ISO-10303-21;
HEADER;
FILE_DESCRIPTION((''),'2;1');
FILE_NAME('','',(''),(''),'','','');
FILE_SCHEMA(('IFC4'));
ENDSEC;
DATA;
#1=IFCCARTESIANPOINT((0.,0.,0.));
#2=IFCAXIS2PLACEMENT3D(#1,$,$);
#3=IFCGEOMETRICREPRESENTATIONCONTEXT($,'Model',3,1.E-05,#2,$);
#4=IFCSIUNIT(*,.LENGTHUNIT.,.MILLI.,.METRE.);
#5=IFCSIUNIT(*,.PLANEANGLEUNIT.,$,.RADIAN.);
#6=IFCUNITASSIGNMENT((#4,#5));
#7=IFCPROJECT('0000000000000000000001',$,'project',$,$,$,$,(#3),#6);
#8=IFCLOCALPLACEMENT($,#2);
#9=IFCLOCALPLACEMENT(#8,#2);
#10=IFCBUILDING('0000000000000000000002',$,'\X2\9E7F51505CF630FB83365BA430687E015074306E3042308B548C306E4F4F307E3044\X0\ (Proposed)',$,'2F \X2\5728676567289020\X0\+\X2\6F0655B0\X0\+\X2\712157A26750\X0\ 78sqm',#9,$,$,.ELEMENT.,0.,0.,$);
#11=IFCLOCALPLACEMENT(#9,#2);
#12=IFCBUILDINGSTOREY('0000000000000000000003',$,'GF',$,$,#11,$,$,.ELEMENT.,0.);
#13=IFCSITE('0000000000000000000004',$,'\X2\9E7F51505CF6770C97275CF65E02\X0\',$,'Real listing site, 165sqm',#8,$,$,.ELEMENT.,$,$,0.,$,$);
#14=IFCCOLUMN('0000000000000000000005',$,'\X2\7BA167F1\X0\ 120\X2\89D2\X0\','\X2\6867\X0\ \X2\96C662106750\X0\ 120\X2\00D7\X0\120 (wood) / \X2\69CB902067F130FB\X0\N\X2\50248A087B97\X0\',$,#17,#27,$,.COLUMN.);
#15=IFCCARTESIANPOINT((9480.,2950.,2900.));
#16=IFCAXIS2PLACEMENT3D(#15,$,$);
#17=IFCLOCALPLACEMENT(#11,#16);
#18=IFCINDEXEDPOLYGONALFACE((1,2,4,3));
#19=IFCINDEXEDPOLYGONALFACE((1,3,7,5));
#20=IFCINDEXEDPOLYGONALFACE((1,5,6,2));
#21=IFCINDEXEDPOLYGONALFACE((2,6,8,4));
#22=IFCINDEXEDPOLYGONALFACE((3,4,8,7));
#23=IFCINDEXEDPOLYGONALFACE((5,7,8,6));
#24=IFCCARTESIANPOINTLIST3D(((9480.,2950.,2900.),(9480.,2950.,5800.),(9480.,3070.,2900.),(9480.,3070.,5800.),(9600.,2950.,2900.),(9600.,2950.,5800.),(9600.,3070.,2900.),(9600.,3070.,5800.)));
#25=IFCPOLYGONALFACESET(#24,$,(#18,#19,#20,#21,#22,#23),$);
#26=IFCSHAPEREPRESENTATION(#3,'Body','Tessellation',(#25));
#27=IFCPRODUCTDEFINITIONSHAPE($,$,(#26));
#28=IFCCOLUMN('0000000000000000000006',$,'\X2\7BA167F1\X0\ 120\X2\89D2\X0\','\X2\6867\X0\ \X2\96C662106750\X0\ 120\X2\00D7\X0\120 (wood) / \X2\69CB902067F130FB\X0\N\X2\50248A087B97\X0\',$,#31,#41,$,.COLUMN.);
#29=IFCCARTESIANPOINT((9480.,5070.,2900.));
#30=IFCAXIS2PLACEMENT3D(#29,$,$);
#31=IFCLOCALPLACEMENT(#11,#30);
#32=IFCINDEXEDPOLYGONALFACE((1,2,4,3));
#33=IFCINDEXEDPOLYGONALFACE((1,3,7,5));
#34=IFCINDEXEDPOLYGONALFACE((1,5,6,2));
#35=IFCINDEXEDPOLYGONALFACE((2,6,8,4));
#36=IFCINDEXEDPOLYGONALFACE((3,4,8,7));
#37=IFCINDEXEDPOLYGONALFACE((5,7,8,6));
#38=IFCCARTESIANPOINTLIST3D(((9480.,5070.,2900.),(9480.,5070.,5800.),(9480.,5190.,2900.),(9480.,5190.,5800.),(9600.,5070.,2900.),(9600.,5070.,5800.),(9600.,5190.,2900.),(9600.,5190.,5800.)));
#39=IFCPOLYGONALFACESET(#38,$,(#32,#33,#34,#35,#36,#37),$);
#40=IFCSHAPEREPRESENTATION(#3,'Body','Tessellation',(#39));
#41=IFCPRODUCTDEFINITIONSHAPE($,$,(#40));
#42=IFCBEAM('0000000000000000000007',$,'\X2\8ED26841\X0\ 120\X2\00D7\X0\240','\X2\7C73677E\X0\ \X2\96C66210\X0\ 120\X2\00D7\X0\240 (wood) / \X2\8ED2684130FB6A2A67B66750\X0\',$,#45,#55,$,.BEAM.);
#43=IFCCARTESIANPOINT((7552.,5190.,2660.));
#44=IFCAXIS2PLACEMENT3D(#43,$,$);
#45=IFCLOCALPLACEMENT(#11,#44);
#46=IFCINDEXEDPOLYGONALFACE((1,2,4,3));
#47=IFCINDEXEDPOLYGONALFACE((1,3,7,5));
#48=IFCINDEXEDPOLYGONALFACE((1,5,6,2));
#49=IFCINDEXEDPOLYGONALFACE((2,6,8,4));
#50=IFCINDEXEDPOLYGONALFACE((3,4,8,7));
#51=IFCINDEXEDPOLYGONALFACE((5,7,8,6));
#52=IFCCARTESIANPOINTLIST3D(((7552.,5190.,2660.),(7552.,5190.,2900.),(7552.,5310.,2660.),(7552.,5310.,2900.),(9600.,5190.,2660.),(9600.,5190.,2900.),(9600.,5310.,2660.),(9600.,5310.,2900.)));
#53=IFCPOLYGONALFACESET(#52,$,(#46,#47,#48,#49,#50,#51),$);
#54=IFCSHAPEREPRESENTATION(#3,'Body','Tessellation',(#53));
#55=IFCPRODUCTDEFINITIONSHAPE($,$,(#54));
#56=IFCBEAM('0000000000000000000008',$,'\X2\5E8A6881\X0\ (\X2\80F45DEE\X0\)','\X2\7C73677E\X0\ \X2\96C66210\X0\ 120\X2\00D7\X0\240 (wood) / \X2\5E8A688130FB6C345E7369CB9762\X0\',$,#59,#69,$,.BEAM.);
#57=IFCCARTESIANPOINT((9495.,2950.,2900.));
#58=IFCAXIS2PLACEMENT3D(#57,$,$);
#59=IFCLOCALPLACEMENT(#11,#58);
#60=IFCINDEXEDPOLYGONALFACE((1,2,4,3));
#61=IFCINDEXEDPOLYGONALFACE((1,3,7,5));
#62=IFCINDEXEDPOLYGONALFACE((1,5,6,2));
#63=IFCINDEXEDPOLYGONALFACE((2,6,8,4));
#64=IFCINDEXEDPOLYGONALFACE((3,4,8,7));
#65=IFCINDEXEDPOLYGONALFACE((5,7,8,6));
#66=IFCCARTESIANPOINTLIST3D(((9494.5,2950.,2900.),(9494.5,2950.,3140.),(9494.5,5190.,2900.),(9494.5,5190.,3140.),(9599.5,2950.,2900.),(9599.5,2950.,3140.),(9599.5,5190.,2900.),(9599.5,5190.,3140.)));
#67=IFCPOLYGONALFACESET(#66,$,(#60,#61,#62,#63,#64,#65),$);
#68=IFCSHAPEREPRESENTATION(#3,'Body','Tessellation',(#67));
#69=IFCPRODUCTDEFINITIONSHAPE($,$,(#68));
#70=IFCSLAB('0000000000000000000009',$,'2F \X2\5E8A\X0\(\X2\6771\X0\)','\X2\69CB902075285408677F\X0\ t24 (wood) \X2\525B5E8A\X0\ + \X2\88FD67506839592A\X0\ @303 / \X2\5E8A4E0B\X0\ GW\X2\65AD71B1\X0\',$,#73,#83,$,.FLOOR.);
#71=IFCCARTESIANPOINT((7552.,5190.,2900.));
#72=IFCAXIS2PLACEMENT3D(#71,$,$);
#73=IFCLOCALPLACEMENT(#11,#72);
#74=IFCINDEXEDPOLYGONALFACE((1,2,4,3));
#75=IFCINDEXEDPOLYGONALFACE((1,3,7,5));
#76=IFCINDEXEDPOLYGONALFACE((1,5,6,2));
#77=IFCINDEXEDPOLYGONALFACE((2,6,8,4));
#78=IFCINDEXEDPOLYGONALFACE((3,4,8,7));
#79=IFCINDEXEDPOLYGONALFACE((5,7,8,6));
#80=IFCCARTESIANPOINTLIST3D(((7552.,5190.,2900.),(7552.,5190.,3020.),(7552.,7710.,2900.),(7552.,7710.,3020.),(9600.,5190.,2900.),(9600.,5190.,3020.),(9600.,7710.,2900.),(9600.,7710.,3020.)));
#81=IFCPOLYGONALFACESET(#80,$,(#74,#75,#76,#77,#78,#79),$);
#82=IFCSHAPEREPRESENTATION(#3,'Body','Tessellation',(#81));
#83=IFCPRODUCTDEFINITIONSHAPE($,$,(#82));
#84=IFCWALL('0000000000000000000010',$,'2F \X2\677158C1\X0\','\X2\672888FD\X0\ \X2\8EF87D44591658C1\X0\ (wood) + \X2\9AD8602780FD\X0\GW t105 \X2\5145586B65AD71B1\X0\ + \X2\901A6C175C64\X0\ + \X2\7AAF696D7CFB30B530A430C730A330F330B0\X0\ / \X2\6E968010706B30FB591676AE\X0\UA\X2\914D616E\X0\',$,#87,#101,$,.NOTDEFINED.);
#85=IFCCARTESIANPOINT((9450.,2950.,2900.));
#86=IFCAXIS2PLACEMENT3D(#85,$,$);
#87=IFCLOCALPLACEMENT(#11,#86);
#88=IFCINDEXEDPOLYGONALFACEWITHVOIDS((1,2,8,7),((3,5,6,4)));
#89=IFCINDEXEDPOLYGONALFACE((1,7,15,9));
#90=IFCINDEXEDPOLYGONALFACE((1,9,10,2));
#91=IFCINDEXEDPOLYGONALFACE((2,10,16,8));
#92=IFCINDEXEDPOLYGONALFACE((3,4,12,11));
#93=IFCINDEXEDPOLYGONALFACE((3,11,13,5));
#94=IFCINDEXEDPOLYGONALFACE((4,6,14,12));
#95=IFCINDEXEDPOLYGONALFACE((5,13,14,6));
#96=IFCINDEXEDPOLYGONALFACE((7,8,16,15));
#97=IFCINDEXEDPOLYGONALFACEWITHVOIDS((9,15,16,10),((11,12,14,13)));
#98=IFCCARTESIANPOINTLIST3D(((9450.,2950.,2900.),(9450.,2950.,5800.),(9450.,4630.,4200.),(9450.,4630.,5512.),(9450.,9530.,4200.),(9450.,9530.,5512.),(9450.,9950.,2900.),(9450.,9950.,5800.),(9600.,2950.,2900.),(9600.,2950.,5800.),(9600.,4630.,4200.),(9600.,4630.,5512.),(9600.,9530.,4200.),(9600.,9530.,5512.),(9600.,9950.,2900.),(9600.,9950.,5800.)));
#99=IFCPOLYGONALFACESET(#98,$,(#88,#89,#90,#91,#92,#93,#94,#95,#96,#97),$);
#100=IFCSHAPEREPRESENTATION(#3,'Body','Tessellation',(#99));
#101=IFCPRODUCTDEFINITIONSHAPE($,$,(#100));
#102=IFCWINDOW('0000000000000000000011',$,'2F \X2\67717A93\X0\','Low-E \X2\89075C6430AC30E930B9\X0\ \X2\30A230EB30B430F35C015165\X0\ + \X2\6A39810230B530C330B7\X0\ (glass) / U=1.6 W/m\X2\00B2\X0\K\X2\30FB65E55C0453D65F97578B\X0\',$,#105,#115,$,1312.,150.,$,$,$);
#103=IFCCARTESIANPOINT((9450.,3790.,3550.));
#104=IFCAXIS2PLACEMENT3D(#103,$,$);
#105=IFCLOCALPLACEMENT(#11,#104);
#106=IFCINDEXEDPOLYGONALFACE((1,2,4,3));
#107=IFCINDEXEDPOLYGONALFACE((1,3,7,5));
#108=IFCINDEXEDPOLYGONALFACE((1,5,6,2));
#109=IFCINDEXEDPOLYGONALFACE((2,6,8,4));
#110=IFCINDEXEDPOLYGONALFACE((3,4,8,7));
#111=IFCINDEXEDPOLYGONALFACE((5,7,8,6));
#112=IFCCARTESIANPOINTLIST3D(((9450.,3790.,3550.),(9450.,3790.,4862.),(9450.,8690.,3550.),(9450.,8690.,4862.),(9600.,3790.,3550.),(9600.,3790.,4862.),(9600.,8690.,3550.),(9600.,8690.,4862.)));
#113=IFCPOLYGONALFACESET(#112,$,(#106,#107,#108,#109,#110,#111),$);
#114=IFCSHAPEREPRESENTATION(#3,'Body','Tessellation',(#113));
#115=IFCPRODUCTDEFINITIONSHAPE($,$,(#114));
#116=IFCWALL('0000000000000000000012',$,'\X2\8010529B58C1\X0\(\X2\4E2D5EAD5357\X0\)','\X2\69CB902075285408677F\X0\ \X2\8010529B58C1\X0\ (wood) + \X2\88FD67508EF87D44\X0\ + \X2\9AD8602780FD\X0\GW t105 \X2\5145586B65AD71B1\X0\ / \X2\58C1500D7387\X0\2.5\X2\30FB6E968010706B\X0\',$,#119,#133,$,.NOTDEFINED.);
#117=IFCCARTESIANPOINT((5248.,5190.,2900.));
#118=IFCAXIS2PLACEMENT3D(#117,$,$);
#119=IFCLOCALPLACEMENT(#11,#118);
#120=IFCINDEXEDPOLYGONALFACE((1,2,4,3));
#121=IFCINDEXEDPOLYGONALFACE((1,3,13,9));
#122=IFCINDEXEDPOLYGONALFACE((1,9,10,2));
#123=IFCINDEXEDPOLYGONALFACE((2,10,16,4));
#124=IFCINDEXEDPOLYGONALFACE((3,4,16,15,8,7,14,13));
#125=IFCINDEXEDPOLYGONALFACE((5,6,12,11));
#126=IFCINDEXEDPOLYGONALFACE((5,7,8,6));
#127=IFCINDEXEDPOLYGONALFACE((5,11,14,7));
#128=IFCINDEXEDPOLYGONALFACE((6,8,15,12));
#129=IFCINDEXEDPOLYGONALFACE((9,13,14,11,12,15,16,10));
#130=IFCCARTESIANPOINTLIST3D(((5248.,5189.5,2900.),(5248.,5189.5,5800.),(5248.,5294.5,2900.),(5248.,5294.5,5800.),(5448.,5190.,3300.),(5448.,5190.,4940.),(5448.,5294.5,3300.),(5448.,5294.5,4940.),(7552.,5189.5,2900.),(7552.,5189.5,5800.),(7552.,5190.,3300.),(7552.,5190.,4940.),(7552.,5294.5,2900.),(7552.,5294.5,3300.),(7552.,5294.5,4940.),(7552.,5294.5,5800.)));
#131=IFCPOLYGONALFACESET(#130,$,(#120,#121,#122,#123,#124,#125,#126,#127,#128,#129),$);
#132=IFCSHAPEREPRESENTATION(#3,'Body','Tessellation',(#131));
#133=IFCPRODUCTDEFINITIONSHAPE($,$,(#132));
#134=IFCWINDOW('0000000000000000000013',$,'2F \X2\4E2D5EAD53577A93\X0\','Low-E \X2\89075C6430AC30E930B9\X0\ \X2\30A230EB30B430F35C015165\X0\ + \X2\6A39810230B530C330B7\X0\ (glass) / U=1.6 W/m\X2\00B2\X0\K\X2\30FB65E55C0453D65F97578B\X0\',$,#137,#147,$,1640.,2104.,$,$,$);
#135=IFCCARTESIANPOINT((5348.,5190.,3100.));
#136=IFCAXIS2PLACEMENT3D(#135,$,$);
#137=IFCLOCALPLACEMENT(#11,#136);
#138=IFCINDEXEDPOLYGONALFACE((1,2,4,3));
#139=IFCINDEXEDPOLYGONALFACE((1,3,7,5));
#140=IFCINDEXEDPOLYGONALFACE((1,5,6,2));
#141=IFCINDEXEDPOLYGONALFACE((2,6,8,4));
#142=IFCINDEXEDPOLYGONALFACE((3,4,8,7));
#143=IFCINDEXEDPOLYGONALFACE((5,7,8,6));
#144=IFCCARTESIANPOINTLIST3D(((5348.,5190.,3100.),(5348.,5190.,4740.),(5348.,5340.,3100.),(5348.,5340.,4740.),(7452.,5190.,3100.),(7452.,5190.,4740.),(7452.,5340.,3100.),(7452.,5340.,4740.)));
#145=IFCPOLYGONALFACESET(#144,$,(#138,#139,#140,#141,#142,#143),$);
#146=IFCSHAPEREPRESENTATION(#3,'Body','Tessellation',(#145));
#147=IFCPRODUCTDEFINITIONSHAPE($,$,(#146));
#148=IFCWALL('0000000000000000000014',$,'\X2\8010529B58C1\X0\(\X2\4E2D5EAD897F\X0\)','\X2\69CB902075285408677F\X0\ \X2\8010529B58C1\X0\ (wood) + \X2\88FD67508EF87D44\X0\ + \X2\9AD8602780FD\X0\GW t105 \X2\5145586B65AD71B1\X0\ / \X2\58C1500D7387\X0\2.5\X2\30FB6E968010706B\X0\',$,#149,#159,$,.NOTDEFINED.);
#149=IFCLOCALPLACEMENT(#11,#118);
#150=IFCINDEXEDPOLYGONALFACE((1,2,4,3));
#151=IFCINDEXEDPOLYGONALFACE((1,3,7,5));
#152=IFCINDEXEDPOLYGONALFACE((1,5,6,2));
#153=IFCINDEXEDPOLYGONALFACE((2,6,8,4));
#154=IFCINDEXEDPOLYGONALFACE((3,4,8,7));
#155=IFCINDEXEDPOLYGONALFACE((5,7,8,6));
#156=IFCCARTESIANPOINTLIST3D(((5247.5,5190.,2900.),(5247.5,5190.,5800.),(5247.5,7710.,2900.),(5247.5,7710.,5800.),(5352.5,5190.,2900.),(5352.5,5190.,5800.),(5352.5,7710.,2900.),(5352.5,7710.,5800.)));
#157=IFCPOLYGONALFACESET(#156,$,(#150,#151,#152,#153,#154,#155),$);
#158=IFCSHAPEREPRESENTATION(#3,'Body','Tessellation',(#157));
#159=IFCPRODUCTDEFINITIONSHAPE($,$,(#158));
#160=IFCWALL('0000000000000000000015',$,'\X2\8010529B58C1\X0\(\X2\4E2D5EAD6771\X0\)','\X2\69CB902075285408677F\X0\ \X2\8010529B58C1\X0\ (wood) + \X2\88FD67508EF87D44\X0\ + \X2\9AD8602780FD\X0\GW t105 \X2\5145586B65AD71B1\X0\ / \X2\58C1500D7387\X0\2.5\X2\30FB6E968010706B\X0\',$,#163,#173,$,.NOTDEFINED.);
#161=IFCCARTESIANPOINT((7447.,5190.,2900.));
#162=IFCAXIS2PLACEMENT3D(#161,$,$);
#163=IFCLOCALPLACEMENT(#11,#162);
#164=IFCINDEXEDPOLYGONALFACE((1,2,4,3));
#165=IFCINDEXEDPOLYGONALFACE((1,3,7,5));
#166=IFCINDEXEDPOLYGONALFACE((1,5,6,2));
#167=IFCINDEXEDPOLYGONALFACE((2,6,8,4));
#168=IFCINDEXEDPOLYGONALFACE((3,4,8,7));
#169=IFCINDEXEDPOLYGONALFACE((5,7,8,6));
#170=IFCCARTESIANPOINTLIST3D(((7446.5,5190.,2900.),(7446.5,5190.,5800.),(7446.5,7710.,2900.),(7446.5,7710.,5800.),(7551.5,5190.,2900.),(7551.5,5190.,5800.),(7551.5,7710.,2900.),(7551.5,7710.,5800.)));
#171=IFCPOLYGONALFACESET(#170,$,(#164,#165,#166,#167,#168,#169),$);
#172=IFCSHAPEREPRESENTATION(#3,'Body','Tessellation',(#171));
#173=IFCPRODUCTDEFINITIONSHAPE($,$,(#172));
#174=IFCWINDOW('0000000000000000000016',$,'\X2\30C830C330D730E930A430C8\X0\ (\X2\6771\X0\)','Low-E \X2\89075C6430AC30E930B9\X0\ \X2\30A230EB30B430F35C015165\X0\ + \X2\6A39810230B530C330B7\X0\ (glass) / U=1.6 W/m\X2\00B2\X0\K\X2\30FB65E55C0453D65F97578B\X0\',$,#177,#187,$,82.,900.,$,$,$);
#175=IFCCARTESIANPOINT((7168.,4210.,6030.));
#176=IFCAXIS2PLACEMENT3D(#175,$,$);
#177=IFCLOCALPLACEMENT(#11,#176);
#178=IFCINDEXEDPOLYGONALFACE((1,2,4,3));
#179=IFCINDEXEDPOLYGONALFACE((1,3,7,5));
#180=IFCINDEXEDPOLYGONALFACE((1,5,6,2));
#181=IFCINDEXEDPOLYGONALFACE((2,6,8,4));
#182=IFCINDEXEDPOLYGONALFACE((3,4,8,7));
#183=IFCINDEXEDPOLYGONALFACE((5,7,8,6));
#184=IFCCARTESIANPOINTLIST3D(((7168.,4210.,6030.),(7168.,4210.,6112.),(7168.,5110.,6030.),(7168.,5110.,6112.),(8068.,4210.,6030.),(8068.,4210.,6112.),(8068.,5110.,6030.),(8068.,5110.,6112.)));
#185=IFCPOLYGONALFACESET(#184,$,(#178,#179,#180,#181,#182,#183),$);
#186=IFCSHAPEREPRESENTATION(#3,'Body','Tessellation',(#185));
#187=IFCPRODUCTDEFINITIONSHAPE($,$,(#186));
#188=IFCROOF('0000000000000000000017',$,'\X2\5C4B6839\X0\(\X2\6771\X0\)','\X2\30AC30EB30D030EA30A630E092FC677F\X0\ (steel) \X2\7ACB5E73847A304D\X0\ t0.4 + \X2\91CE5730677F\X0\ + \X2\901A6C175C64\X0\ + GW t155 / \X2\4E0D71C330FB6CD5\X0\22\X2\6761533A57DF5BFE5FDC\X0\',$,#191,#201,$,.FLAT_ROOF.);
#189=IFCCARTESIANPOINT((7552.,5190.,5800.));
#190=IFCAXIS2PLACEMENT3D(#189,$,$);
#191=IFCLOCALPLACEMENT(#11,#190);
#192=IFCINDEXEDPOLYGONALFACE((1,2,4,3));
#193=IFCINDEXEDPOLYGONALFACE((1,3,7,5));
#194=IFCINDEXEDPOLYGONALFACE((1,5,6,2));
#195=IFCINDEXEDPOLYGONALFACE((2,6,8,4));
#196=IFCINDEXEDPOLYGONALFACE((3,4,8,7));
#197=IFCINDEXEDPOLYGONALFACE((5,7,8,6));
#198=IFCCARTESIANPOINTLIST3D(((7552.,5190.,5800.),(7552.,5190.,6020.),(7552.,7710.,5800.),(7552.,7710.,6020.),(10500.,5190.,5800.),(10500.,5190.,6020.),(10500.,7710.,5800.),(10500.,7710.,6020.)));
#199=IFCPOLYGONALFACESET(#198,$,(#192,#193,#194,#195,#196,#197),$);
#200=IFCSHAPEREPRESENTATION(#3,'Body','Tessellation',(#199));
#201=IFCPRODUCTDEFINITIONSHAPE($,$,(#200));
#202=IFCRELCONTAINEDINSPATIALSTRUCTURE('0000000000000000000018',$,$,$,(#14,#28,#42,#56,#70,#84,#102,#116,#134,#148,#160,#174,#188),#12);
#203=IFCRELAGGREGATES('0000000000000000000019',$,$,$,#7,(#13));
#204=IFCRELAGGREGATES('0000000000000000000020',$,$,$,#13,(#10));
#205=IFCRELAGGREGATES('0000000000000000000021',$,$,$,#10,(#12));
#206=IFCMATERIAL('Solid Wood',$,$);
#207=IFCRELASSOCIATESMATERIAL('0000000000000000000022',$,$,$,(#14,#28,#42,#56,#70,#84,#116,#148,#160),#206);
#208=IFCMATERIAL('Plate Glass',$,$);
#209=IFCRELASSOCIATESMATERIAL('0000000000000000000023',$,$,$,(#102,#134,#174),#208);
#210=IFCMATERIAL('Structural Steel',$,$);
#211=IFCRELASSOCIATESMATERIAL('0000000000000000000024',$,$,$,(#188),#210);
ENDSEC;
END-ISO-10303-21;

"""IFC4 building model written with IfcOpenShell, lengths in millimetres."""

from ifc_helpers import new_model, si_unit, frame, frame_2d, origin, place, context, project, spatial, rectangle, extrude, material, element, fill, save


model = new_model("IFC4")

# Units and contexts
model_context = context("Model", 3, precision=1e-05, world=origin())
ifc_project = project(units=[si_unit("LENGTHUNIT", "METRE", prefix="MILLI"), si_unit("PLANEANGLEUNIT", "RADIAN")], contexts=[model_context])

# Site, building, storey
site_placement = place(None, origin())
site = spatial("IfcSite", under=ifc_project, at=site_placement, Name="鹿児島県霧島市", ObjectType="Real listing site, 165sqm", CompositionType="ELEMENT", RefElevation=0.0)
building_placement = place(site_placement, origin())
building = spatial("IfcBuilding", under=site, at=building_placement, Name="鹿児島・茶室と縁側のある和の住まい (Proposed)", ObjectType="2F 在来木造+漆喰+無垢材 78sqm", CompositionType="ELEMENT", ElevationOfRefHeight=0.0, ElevationOfTerrain=0.0)
storey_placement = place(building_placement, origin())
storey = spatial("IfcBuildingStorey", under=building, at=storey_placement, Name="GF", CompositionType="ELEMENT", Elevation=0.0)

# Columns
ifc_material_1 = material(Name="Solid Wood")
column_1_placement = place(storey_placement, frame((9480.0, 2950.0, 2900.0)))
element("IfcColumn", 1, at=column_1_placement, inside=storey, material=ifc_material_1, Name="管柱 120角", Description="桧 集成材 120×120 (wood) / 構造柱・N値計算", PredefinedType="COLUMN", context=model_context, shape_type="SweptSolid", body=[
    extrude(rectangle(XDim=120.0, YDim=120.0, at=frame_2d((60.0, 60.0))), frame((9480.0, 2950.0, 2900.0)), (0.0, 0.0, 1.0), 2900.0),
])
column_2_placement = place(storey_placement, frame((9480.0, 5070.0, 2900.0)))
element("IfcColumn", 2, at=column_2_placement, inside=storey, material=ifc_material_1, Name="管柱 120角", Description="桧 集成材 120×120 (wood) / 構造柱・N値計算", PredefinedType="COLUMN", context=model_context, shape_type="SweptSolid", body=[
    extrude(rectangle(XDim=120.0, YDim=120.0, at=frame_2d((60.0, 60.0))), frame((9480.0, 5070.0, 2900.0)), (0.0, 0.0, 1.0), 2900.0),
])

# Beams
beam_1_placement = place(storey_placement, frame((7552.0, 5190.0, 2660.0)))
element("IfcBeam", 3, at=beam_1_placement, inside=storey, material=ifc_material_1, Name="軒桁 120×240", Description="米松 集成 120×240 (wood) / 軒桁・横架材", PredefinedType="BEAM", context=model_context, shape_type="SweptSolid", body=[
    extrude(rectangle(XDim=2048.0, YDim=120.0, at=frame_2d((1024.0, 60.0))), frame((7552.0, 5190.0, 2660.0)), (0.0, 0.0, 1.0), 240.0),
])
beam_2_placement = place(storey_placement, frame((9495.0, 2950.0, 2900.0)))
element("IfcBeam", 4, at=beam_2_placement, inside=storey, material=ifc_material_1, Name="床梁 (胴差)", Description="米松 集成 120×240 (wood) / 床梁・水平構面", PredefinedType="BEAM", context=model_context, shape_type="SweptSolid", body=[
    extrude(rectangle(XDim=105.0, YDim=2240.0, at=frame_2d((52.0, 1120.0))), frame((9495.0, 2950.0, 2900.0)), (0.0, 0.0, 1.0), 240.0),
])

# Slab
slab_placement = place(storey_placement, frame((7552.0, 5190.0, 2900.0)))
element("IfcSlab", 5, at=slab_placement, inside=storey, material=ifc_material_1, Name="2F 床(東)", Description="構造用合板 t24 (wood) 剛床 + 製材根太 @303 / 床下 GW断熱", PredefinedType="FLOOR", context=model_context, shape_type="SweptSolid", body=[
    extrude(rectangle(XDim=2048.0, YDim=2520.0, at=frame_2d((1024.0, 1260.0))), frame((7552.0, 5190.0, 2900.0)), (0.0, 0.0, 1.0), 120.0),
])

# Walls, openings, windows
wall_1_placement = place(storey_placement, frame((9450.0, 2950.0, 2900.0)))
wall_1 = element("IfcWall", 6, at=wall_1_placement, inside=storey, material=ifc_material_1, Name="2F 東壁", Description="木製 軸組外壁 (wood) + 高性能GW t105 充填断熱 + 通気層 + 窯業系サイディング / 準耐火・外皮UA配慮", PredefinedType="NOTDEFINED", context=model_context, shape_type="SweptSolid", body=[
    extrude(rectangle(XDim=150.0, YDim=7000.0, at=frame_2d((75.0, 3500.0))), frame((9450.0, 2950.0, 2900.0)), (0.0, 0.0, 1.0), 2900.0),
])
opening_1_placement = place(storey_placement, frame((9450.0, 3790.0, 3550.0)))
opening_1 = element("IfcOpeningElement", 7, at=opening_1_placement, cuts=wall_1, PredefinedType="NOTDEFINED", context=model_context, shape_type="SweptSolid", body=[
    extrude(rectangle(XDim=150.0, YDim=4900.0, at=frame_2d((75.0, 2450.0))), frame((9450.0, 3790.0, 3550.0)), (0.0, 0.0, 1.0), 1312.0),
])
ifc_material_2 = material(Name="Plate Glass")
window_1_placement = place(storey_placement, frame((9450.0, 3790.0, 3550.0)))
window_1 = element("IfcWindow", 8, at=window_1_placement, inside=storey, material=ifc_material_2, Name="2F 東窓", Description="Low-E 複層ガラス アルゴン封入 + 樹脂サッシ (glass) / U=1.6 W/m²K・日射取得型", OverallHeight=1312.0, OverallWidth=150.0, context=model_context, shape_type="SweptSolid", body=[
    extrude(rectangle(XDim=150.0, YDim=4900.0, at=frame_2d((75.0, 2450.0))), frame((9450.0, 3790.0, 3550.0)), (0.0, 0.0, 1.0), 1312.0),
])
fill(opening_1, window_1)
wall_2_placement = place(storey_placement, frame((5248.0, 5190.0, 2900.0)))
wall_2 = element("IfcWall", 9, at=wall_2_placement, inside=storey, material=ifc_material_1, Name="耐力壁(中庭南)", Description="構造用合板 耐力壁 (wood) + 製材軸組 + 高性能GW t105 充填断熱 / 壁倍率2.5・準耐火", PredefinedType="NOTDEFINED", context=model_context, shape_type="SweptSolid", body=[
    extrude(rectangle(XDim=2304.0, YDim=105.0, at=frame_2d((1152.0, 52.0))), frame((5248.0, 5190.0, 2900.0)), (0.0, 0.0, 1.0), 2900.0),
])
opening_2_placement = place(storey_placement, frame((5348.0, 5190.0, 3100.0)))
opening_2 = element("IfcOpeningElement", 10, at=opening_2_placement, cuts=wall_2, PredefinedType="NOTDEFINED", context=model_context, shape_type="SweptSolid", body=[
    extrude(rectangle(XDim=2104.0, YDim=150.0, at=frame_2d((1052.0, 75.0))), frame((5348.0, 5190.0, 3100.0)), (0.0, 0.0, 1.0), 1640.0),
])
window_2_placement = place(storey_placement, frame((5348.0, 5190.0, 3100.0)))
window_2 = element("IfcWindow", 11, at=window_2_placement, inside=storey, material=ifc_material_2, Name="2F 中庭南窓", Description="Low-E 複層ガラス アルゴン封入 + 樹脂サッシ (glass) / U=1.6 W/m²K・日射取得型", OverallHeight=1640.0, OverallWidth=2104.0, context=model_context, shape_type="SweptSolid", body=[
    extrude(rectangle(XDim=2104.0, YDim=150.0, at=frame_2d((1052.0, 75.0))), frame((5348.0, 5190.0, 3100.0)), (0.0, 0.0, 1.0), 1640.0),
])
fill(opening_2, window_2)

# Walls
wall_3_placement = place(storey_placement, frame((5248.0, 5190.0, 2900.0)))
element("IfcWall", 12, at=wall_3_placement, inside=storey, material=ifc_material_1, Name="耐力壁(中庭西)", Description="構造用合板 耐力壁 (wood) + 製材軸組 + 高性能GW t105 充填断熱 / 壁倍率2.5・準耐火", PredefinedType="NOTDEFINED", context=model_context, shape_type="SweptSolid", body=[
    extrude(rectangle(XDim=105.0, YDim=2520.0, at=frame_2d((52.0, 1260.0))), frame((5248.0, 5190.0, 2900.0)), (0.0, 0.0, 1.0), 2900.0),
])
wall_4_placement = place(storey_placement, frame((7447.0, 5190.0, 2900.0)))
element("IfcWall", 13, at=wall_4_placement, inside=storey, material=ifc_material_1, Name="耐力壁(中庭東)", Description="構造用合板 耐力壁 (wood) + 製材軸組 + 高性能GW t105 充填断熱 / 壁倍率2.5・準耐火", PredefinedType="NOTDEFINED", context=model_context, shape_type="SweptSolid", body=[
    extrude(rectangle(XDim=105.0, YDim=2520.0, at=frame_2d((52.0, 1260.0))), frame((7447.0, 5190.0, 2900.0)), (0.0, 0.0, 1.0), 2900.0),
])

# Window
window_3_placement = place(storey_placement, frame((7168.0, 4210.0, 6030.0)))
element("IfcWindow", 14, at=window_3_placement, inside=storey, material=ifc_material_2, Name="トップライト (東)", Description="Low-E 複層ガラス アルゴン封入 + 樹脂サッシ (glass) / U=1.6 W/m²K・日射取得型", OverallHeight=82.0, OverallWidth=900.0, context=model_context, shape_type="SweptSolid", body=[
    extrude(rectangle(XDim=900.0, YDim=900.0, at=frame_2d((450.0, 450.0))), frame((7168.0, 4210.0, 6030.0)), (0.0, 0.0, 1.0), 82.0),
])

# Roof
ifc_material_3 = material(Name="Structural Steel")
for number, where, name in (
    (15, (7552.0, 5190.0, 5800.0), "屋根(東)"),
):
    element("IfcRoof", number, at=place(storey_placement, frame(where)), inside=storey, material=ifc_material_3, Name=name, Description="ガルバリウム鋼板 (steel) 立平葺き t0.4 + 野地板 + 通気層 + GW t155 / 不燃・法22条区域対応", PredefinedType="FLAT_ROOF", context=model_context, shape_type="SweptSolid", body=[
        extrude(rectangle(XDim=2948.0, YDim=2520.0, at=frame_2d((1474.0, 1260.0))), frame((7552.0, 5190.0, 5800.0)), (0.0, 0.0, 1.0), 220.0),
    ])

save(model, "model.ifc")
